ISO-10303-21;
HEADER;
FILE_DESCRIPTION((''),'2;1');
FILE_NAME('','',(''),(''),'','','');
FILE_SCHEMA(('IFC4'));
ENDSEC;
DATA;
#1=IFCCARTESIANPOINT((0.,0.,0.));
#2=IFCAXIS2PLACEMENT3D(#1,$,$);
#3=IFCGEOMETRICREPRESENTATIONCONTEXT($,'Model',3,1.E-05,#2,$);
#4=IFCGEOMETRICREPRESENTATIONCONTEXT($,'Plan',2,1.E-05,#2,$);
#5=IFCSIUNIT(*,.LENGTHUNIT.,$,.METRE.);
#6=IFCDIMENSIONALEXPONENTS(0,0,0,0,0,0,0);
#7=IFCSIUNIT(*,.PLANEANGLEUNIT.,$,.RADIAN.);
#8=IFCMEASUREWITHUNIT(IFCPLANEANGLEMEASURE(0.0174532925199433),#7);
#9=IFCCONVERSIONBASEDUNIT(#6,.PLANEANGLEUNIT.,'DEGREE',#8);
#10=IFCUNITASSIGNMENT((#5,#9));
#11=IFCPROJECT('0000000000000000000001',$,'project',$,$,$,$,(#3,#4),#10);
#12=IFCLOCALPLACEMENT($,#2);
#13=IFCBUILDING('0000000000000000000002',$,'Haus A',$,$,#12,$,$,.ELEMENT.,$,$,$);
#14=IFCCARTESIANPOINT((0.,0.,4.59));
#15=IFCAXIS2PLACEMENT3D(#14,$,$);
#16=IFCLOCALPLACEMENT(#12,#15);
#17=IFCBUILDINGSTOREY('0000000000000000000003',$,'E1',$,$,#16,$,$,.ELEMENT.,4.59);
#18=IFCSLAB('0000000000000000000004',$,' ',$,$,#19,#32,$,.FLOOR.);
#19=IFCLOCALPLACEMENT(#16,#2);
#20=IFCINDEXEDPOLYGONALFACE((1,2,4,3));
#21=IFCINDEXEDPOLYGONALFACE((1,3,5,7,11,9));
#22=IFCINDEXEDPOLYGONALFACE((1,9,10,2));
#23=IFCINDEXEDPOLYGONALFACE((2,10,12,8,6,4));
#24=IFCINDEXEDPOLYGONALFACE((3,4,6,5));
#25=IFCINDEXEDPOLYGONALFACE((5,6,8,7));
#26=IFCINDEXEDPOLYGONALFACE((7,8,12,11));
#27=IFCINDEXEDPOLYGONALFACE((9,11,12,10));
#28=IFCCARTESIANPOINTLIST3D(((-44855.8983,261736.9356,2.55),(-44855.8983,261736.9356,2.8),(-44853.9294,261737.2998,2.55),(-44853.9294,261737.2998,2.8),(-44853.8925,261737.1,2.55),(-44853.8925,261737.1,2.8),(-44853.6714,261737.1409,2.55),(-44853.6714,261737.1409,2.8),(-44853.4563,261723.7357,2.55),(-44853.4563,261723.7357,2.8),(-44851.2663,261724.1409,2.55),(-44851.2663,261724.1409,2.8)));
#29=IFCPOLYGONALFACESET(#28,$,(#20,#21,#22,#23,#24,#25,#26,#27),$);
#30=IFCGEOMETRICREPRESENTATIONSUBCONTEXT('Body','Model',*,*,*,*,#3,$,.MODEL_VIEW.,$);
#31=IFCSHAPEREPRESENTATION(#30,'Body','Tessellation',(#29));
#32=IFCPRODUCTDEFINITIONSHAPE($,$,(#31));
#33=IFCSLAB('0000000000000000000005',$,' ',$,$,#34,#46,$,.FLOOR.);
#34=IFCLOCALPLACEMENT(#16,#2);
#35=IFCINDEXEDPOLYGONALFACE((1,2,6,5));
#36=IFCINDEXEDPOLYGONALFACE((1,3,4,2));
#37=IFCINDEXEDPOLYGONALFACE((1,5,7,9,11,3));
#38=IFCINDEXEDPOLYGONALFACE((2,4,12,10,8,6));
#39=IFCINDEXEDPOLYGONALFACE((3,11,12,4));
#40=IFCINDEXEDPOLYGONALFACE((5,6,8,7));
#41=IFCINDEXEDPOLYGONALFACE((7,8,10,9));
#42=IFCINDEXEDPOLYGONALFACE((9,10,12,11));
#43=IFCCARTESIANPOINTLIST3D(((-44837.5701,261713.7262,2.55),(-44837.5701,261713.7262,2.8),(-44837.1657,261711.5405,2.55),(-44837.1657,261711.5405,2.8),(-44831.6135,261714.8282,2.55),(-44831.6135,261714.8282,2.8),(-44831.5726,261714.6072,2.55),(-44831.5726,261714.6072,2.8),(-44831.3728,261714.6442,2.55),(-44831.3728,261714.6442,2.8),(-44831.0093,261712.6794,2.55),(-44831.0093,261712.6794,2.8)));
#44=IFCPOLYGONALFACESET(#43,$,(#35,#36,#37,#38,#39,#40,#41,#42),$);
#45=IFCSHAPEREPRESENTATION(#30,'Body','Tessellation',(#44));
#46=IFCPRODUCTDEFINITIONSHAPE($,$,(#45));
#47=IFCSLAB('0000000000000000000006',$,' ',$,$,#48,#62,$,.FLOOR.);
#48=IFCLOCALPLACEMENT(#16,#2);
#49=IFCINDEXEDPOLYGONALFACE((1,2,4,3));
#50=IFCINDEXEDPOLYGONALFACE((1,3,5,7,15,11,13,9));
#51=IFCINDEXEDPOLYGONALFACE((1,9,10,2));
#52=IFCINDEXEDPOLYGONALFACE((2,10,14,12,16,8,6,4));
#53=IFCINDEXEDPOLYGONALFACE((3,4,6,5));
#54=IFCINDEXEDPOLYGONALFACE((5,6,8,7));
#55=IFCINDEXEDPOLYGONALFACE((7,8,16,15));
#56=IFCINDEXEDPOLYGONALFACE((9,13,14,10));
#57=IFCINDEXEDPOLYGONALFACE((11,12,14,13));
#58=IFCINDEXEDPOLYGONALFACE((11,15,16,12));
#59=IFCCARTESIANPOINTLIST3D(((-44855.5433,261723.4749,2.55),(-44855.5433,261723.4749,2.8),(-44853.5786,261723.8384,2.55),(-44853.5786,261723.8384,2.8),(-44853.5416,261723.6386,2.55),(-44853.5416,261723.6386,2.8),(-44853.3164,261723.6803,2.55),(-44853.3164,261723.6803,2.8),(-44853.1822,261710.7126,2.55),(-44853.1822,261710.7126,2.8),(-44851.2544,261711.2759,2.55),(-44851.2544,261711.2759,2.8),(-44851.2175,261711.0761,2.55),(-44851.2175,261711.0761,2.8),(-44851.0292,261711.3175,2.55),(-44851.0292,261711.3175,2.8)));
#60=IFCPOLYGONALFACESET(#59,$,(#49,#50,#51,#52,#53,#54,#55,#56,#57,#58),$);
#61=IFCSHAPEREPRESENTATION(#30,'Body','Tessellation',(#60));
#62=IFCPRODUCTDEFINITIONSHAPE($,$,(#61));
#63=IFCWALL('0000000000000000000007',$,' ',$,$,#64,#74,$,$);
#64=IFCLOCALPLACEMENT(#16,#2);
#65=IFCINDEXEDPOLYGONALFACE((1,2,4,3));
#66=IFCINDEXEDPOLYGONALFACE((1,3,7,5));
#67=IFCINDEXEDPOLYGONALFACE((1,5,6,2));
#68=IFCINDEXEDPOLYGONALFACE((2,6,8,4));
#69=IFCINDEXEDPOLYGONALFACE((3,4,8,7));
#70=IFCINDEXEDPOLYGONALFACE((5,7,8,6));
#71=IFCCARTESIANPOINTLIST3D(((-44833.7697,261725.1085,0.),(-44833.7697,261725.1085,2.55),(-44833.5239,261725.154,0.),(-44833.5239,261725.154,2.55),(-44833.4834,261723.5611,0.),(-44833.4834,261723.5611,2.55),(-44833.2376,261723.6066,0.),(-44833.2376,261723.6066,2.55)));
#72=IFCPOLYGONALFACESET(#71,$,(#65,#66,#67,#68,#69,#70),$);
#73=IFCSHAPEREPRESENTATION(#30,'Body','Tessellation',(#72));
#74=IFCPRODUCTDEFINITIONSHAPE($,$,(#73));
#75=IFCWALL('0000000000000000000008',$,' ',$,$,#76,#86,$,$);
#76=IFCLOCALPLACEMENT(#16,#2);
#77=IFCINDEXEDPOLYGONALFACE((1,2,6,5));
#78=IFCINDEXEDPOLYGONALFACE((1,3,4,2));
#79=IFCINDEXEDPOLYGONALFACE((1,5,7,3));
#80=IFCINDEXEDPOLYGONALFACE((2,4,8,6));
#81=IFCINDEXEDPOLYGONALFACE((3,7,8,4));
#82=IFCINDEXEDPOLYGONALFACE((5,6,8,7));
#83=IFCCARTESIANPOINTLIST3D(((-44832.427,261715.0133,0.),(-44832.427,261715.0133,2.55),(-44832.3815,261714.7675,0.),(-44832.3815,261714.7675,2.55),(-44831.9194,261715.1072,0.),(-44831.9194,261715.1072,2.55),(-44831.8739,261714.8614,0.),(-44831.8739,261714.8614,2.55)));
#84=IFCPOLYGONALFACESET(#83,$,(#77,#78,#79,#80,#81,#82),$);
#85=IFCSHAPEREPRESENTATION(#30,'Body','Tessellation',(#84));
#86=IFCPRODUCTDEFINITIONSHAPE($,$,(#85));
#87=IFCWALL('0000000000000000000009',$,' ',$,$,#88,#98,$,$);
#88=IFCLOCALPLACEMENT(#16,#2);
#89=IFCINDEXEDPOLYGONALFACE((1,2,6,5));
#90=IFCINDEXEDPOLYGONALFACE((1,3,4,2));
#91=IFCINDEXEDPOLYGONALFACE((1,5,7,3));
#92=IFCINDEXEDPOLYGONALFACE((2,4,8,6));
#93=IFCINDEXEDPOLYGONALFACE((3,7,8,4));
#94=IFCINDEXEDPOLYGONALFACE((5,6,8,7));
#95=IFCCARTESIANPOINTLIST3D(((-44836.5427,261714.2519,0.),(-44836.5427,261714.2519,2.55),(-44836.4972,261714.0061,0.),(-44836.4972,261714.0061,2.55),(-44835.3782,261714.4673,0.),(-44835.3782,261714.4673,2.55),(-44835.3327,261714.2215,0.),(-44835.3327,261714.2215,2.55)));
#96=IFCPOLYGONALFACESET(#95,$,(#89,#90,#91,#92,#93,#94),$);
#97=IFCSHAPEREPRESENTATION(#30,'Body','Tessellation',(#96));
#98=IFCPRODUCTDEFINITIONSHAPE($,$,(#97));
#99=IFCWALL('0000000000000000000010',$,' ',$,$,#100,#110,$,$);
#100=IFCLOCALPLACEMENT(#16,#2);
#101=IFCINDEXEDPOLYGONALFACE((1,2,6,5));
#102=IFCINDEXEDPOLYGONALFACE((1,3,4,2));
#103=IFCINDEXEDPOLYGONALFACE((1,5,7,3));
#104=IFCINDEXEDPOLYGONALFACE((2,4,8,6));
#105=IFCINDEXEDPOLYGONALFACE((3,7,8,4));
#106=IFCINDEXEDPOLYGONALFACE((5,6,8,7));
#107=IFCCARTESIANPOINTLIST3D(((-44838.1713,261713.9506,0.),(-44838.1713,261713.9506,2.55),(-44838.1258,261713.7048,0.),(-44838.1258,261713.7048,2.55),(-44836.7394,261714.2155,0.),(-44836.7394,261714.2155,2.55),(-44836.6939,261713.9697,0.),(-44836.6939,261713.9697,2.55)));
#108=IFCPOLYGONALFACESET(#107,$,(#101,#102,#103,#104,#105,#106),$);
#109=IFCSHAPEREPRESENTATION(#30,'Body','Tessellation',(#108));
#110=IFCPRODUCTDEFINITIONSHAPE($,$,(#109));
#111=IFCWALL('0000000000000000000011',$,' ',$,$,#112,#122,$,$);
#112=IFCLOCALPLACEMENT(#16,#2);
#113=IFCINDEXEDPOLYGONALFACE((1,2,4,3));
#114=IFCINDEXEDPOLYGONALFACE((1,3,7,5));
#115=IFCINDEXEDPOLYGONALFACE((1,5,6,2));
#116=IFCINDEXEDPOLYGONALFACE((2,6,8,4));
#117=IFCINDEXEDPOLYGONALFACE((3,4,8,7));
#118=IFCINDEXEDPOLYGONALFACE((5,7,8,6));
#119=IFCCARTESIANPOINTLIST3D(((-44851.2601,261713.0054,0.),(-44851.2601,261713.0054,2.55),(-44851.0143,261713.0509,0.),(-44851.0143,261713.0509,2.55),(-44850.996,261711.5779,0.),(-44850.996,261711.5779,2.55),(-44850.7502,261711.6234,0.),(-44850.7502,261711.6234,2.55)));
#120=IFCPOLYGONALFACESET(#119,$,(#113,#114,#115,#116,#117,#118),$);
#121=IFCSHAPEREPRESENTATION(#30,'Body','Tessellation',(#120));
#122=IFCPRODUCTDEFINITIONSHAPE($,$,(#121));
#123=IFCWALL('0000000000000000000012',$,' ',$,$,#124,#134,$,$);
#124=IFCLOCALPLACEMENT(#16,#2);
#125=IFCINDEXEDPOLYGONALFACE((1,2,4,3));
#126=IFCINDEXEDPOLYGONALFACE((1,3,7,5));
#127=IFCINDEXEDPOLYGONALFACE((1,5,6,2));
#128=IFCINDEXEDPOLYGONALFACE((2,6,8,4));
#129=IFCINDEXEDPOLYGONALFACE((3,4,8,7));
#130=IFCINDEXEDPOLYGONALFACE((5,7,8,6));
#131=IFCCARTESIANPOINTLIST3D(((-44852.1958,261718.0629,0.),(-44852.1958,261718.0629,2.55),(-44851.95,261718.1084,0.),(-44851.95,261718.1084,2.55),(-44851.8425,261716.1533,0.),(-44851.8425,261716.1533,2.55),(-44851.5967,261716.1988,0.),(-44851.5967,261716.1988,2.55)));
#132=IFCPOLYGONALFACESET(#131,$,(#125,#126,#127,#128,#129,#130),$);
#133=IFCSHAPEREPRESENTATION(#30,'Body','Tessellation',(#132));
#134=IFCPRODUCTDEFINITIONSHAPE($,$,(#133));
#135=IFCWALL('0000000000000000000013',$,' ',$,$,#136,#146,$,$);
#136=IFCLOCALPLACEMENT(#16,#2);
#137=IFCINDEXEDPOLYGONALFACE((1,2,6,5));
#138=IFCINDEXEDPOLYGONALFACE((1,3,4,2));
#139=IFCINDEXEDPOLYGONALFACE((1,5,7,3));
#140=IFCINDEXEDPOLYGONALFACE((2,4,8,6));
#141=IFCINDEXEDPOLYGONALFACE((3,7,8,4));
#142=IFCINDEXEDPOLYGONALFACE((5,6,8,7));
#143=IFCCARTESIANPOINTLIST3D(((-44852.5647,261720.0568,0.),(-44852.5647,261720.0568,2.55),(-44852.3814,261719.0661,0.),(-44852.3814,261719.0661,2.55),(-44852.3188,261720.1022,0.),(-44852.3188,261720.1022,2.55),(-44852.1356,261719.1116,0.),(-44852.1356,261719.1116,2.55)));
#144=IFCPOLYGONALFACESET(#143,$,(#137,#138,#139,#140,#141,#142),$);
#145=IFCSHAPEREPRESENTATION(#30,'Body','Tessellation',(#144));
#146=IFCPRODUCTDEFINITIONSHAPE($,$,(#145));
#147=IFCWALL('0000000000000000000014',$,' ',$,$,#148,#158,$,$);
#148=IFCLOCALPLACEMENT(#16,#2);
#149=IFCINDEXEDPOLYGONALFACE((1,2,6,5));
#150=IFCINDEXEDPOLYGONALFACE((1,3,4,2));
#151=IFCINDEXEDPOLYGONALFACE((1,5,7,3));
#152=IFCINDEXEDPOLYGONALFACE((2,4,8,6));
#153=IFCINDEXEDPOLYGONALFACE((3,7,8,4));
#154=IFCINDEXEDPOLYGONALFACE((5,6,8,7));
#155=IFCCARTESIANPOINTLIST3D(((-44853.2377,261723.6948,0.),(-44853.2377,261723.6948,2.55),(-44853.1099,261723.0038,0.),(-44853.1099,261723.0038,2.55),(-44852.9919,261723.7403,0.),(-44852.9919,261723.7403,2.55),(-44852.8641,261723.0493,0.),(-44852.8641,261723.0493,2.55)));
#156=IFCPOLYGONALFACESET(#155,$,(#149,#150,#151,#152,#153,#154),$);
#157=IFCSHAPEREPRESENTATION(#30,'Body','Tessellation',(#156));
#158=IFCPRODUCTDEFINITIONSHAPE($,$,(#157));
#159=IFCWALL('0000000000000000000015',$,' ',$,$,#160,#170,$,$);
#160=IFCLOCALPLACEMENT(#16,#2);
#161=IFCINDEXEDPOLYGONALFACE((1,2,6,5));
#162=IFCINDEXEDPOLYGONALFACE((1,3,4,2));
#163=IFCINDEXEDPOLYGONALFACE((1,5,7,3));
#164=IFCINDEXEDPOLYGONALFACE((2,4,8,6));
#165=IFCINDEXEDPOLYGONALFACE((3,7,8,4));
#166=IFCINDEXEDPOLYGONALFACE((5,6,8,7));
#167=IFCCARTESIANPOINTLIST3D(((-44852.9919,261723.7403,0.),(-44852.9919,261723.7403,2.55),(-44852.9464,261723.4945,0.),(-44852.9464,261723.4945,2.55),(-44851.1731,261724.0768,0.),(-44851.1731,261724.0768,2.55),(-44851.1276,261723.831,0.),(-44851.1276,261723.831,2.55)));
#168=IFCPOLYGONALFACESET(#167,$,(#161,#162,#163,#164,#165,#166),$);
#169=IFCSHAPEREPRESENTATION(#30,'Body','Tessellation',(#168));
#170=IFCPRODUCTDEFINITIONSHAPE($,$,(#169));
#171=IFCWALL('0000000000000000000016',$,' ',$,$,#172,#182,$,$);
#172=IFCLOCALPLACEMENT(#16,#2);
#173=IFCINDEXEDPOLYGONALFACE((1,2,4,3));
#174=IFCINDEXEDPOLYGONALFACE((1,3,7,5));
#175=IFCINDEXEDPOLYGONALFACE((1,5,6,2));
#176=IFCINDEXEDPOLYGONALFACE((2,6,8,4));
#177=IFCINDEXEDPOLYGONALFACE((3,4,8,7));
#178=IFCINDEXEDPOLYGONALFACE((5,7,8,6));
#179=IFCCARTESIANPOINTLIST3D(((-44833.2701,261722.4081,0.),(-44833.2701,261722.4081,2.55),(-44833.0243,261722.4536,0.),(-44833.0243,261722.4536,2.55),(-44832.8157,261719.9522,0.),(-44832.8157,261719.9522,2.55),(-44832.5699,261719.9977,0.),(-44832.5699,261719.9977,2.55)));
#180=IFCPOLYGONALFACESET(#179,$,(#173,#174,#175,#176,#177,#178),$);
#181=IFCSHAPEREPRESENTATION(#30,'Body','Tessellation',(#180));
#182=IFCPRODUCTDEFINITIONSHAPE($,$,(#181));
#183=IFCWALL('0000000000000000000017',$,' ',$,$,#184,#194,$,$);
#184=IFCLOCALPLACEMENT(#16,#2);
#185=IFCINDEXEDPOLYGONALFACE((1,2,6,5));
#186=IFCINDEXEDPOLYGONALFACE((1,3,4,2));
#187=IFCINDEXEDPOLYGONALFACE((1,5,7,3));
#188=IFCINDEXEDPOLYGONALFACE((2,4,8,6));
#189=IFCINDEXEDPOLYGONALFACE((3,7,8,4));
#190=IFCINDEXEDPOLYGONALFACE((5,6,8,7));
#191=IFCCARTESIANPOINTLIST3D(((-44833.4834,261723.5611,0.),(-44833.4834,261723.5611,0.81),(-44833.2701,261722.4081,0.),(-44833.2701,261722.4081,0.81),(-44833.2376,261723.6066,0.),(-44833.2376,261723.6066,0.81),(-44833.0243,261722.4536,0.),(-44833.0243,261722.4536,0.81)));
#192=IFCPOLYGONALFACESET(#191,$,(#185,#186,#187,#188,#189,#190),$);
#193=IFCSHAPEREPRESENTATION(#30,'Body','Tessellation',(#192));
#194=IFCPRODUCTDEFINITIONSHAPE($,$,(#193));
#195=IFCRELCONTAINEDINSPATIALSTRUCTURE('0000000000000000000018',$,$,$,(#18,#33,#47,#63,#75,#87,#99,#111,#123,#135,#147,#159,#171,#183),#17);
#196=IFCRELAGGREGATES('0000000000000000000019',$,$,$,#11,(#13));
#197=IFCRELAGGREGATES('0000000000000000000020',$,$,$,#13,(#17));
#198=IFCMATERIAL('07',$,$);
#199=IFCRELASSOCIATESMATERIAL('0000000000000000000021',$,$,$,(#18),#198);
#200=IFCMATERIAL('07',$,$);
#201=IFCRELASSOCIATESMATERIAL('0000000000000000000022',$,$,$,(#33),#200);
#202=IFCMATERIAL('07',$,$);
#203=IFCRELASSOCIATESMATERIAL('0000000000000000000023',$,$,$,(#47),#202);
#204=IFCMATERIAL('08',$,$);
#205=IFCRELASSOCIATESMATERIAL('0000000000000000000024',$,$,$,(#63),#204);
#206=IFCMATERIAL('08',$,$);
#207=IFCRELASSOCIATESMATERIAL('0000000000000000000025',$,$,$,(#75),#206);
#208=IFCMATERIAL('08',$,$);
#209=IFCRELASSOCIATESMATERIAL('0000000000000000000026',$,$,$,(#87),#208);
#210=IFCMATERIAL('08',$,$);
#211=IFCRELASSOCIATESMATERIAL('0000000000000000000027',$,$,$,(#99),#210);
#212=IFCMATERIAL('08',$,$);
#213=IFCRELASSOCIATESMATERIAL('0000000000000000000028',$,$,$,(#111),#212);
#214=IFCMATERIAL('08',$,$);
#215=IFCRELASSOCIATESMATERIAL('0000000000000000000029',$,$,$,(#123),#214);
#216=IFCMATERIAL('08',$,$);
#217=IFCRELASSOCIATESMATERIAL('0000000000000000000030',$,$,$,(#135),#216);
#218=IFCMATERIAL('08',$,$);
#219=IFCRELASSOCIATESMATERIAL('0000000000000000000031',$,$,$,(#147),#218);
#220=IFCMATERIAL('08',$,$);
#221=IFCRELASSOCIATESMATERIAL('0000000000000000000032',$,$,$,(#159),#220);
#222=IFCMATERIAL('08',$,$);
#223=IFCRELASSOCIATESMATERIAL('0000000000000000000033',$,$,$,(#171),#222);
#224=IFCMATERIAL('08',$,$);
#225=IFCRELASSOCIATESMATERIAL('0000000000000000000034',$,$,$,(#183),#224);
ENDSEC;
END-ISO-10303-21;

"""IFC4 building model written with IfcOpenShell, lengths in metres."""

from ifc_helpers import new_model, entity, si_unit, converted_unit, frame, frame_2d, origin, origin_with_axes, place, context, subcontext, project, spatial, polyline, rectangle, outline, extrude, material, element, save


model = new_model("IFC4")

# Units and contexts
model_context = context("Model", 3, precision=1e-05, world=origin())
plan_context = context("Plan", 2, precision=1e-05, world=origin())
body_context = subcontext(model_context, "Body", "Model", "MODEL_VIEW")
ifc_project = project(units=[si_unit("LENGTHUNIT", "METRE"), converted_unit("PLANEANGLEUNIT", "DEGREE", entity("IfcPlaneAngleMeasure", 0.0174532925199433), si_unit("PLANEANGLEUNIT", "RADIAN"), dimensions=[0, 0, 0, 0, 0, 0, 0])], contexts=[model_context, plan_context])

# Building, storey
building_placement = place(None, origin())
building = spatial("IfcBuilding", under=ifc_project, at=building_placement, Name="Haus A", CompositionType="ELEMENT")
storey_placement = place(building_placement, frame((0.0, 0.0, 4.59)))
storey = spatial("IfcBuildingStorey", under=building, at=storey_placement, Name="E1", CompositionType="ELEMENT", Elevation=4.59)

# Slabs
ifc_material_1 = material(Name="07")
slab_1_placement = place(storey_placement, frame((-44855.8983, 261723.7357, 2.55)))
element("IfcSlab", 1, at=slab_1_placement, inside=storey, material=ifc_material_1, Name=" ", PredefinedType="FLOOR", context=body_context, shape_type="SweptSolid", body=[
    extrude(outline(polyline([(0.0, 13.1998), (2.4421, 0.0), (4.632, 0.4051), (2.2269, 13.4052), (2.0058, 13.3643), (1.9689, 13.5641), (0.0, 13.1998)])), origin_with_axes(), (0.0, 0.0, 1.0), 0.25),
])
ifc_material_2 = material(Name="07")
slab_2_placement = place(storey_placement, frame((-44837.5701, 261711.5405, 2.55)))
element("IfcSlab", 2, at=slab_2_placement, inside=storey, material=ifc_material_2, Name=" ", PredefinedType="FLOOR", context=body_context, shape_type="SweptSolid", body=[
    extrude(outline(polyline([(0.0, 2.1858), (0.4044, 0.0), (6.5608, 1.139), (6.1973, 3.1037), (5.9975, 3.0667), (5.9566, 3.2878), (0.0, 2.1858)])), origin_with_axes(), (0.0, 0.0, 1.0), 0.25),
])
ifc_material_3 = material(Name="07")
slab_3_placement = place(storey_placement, frame((-44855.5433, 261710.7126, 2.55)))
element("IfcSlab", 3, at=slab_3_placement, inside=storey, material=ifc_material_3, Name=" ", PredefinedType="FLOOR", context=body_context, shape_type="SweptSolid", body=[
    extrude(outline(polyline([(1.9647, 13.1258), (0.0, 12.7623), (2.3611, 0.0), (4.3258, 0.3635), (4.2889, 0.5633), (4.5141, 0.605), (2.2269, 12.9677), (2.0017, 12.926), (1.9647, 13.1258)])), origin_with_axes(), (0.0, 0.0, 1.0), 0.25),
])

# Walls
ifc_material_4 = material(Name="08")
wall_1_placement = place(storey_placement, frame((-44833.2376, 261723.6066, 0.0), z_axis=(0.0, 0.0, 1.0), x_axis=(-0.18192, 0.983313, 0.0)))
element("IfcWall", 4, at=wall_1_placement, inside=storey, material=ifc_material_4, Name=" ", context=body_context, shape_type="SweptSolid", body=[
    extrude(rectangle(XDim=1.5737, YDim=0.25, at=frame_2d((0.7868, 0.125), x_axis=(1.0, 0.0))), origin_with_axes(), (0.0, 0.0, 1.0), 2.55),
])
ifc_material_5 = material(Name="08")
wall_2_placement = place(storey_placement, frame((-44832.3815, 261714.7675, 0.0), z_axis=(0.0, 0.0, 1.0), x_axis=(0.983313, 0.18192, 0.0)))
element("IfcWall", 5, at=wall_2_placement, inside=storey, material=ifc_material_5, Name=" ", context=body_context, shape_type="SweptSolid", body=[
    extrude(rectangle(XDim=0.5162, YDim=0.25, at=frame_2d((0.2581, 0.125), x_axis=(1.0, 0.0))), origin_with_axes(), (0.0, 0.0, 1.0), 2.55),
])
ifc_material_6 = material(Name="08")
wall_3_placement = place(storey_placement, frame((-44836.4972, 261714.0061, 0.0), z_axis=(0.0, 0.0, 1.0), x_axis=(0.983313, 0.18192, 0.0)))
element("IfcWall", 6, at=wall_3_placement, inside=storey, material=ifc_material_6, Name=" ", context=body_context, shape_type="SweptSolid", body=[
    extrude(rectangle(XDim=1.1842, YDim=0.25, at=frame_2d((0.5921, 0.125), x_axis=(1.0, 0.0))), origin_with_axes(), (0.0, 0.0, 1.0), 2.55),
])
ifc_material_7 = material(Name="08")
wall_4_placement = place(storey_placement, frame((-44838.1258, 261713.7048, 0.0), z_axis=(0.0, 0.0, 1.0), x_axis=(0.983313, 0.18192, 0.0)))
element("IfcWall", 7, at=wall_4_placement, inside=storey, material=ifc_material_7, Name=" ", context=body_context, shape_type="SweptSolid", body=[
    extrude(rectangle(XDim=1.4562, YDim=0.25, at=frame_2d((0.7281, 0.125), x_axis=(1.0, 0.0))), origin_with_axes(), (0.0, 0.0, 1.0), 2.55),
])
ifc_material_8 = material(Name="08")
wall_5_placement = place(storey_placement, frame((-44851.2601, 261713.0054, 0.0), z_axis=(0.0, 0.0, 1.0), x_axis=(0.18192, -0.983313, 0.0)))
element("IfcWall", 8, at=wall_5_placement, inside=storey, material=ifc_material_8, Name=" ", context=body_context, shape_type="SweptSolid", body=[
    extrude(rectangle(XDim=1.4517, YDim=0.25, at=frame_2d((0.7259, 0.125), x_axis=(1.0, 0.0))), origin_with_axes(), (0.0, 0.0, 1.0), 2.55),
])
ifc_material_9 = material(Name="08")
wall_6_placement = place(storey_placement, frame((-44852.1958, 261718.0629, 0.0), z_axis=(0.0, 0.0, 1.0), x_axis=(0.18192, -0.983313, 0.0)))
element("IfcWall", 9, at=wall_6_placement, inside=storey, material=ifc_material_9, Name=" ", context=body_context, shape_type="SweptSolid", body=[
    extrude(rectangle(XDim=1.942, YDim=0.25, at=frame_2d((0.971, 0.125), x_axis=(1.0, 0.0))), origin_with_axes(), (0.0, 0.0, 1.0), 2.55),
])
ifc_material_10 = material(Name="08")
wall_7_placement = place(storey_placement, frame((-44852.5647, 261720.0568, 0.0), z_axis=(0.0, 0.0, 1.0), x_axis=(0.18192, -0.983313, 0.0)))
element("IfcWall", 10, at=wall_7_placement, inside=storey, material=ifc_material_10, Name=" ", context=body_context, shape_type="SweptSolid", body=[
    extrude(rectangle(XDim=1.0075, YDim=0.25, at=frame_2d((0.5037, 0.125), x_axis=(1.0, 0.0))), origin_with_axes(), (0.0, 0.0, 1.0), 2.55),
])
ifc_material_11 = material(Name="08")
wall_8_placement = place(storey_placement, frame((-44853.2377, 261723.6948, 0.0), z_axis=(0.0, 0.0, 1.0), x_axis=(0.18192, -0.983313, 0.0)))
element("IfcWall", 11, at=wall_8_placement, inside=storey, material=ifc_material_11, Name=" ", context=body_context, shape_type="SweptSolid", body=[
    extrude(rectangle(XDim=0.7027, YDim=0.25, at=frame_2d((0.3514, 0.125), x_axis=(1.0, 0.0))), origin_with_axes(), (0.0, 0.0, 1.0), 2.55),
])
ifc_material_12 = material(Name="08")
wall_9_placement = place(storey_placement, frame((-44851.1731, 261724.0768, 0.0), z_axis=(0.0, 0.0, 1.0), x_axis=(-0.983313, -0.18192, 0.0)))
element("IfcWall", 12, at=wall_9_placement, inside=storey, material=ifc_material_12, Name=" ", context=body_context, shape_type="SweptSolid", body=[
    extrude(rectangle(XDim=1.8497, YDim=0.25, at=frame_2d((0.9248, 0.125), x_axis=(1.0, 0.0))), origin_with_axes(), (0.0, 0.0, 1.0), 2.55),
])
ifc_material_13 = material(Name="08")
wall_10_placement = place(storey_placement, frame((-44832.5699, 261719.9977, 0.0), z_axis=(0.0, 0.0, 1.0), x_axis=(-0.18192, 0.983313, 0.0)))
element("IfcWall", 13, at=wall_10_placement, inside=storey, material=ifc_material_13, Name=" ", context=body_context, shape_type="SweptSolid", body=[
    extrude(rectangle(XDim=2.4976, YDim=0.25, at=frame_2d((1.2488, 0.125), x_axis=(1.0, 0.0))), origin_with_axes(), (0.0, 0.0, 1.0), 2.55),
])
ifc_material_14 = material(Name="08")
wall_11_placement = place(storey_placement, frame((-44833.0243, 261722.4536, 0.0), z_axis=(0.0, 0.0, 1.0), x_axis=(-0.18192, 0.983313, 0.0)))
element("IfcWall", 14, at=wall_11_placement, inside=storey, material=ifc_material_14, Name=" ", context=body_context, shape_type="SweptSolid", body=[
    extrude(rectangle(XDim=1.1726, YDim=0.25, at=frame_2d((0.5863, 0.125), x_axis=(1.0, 0.0))), origin_with_axes(), (0.0, 0.0, 1.0), 0.81),
])

save(model, "model.ifc")
